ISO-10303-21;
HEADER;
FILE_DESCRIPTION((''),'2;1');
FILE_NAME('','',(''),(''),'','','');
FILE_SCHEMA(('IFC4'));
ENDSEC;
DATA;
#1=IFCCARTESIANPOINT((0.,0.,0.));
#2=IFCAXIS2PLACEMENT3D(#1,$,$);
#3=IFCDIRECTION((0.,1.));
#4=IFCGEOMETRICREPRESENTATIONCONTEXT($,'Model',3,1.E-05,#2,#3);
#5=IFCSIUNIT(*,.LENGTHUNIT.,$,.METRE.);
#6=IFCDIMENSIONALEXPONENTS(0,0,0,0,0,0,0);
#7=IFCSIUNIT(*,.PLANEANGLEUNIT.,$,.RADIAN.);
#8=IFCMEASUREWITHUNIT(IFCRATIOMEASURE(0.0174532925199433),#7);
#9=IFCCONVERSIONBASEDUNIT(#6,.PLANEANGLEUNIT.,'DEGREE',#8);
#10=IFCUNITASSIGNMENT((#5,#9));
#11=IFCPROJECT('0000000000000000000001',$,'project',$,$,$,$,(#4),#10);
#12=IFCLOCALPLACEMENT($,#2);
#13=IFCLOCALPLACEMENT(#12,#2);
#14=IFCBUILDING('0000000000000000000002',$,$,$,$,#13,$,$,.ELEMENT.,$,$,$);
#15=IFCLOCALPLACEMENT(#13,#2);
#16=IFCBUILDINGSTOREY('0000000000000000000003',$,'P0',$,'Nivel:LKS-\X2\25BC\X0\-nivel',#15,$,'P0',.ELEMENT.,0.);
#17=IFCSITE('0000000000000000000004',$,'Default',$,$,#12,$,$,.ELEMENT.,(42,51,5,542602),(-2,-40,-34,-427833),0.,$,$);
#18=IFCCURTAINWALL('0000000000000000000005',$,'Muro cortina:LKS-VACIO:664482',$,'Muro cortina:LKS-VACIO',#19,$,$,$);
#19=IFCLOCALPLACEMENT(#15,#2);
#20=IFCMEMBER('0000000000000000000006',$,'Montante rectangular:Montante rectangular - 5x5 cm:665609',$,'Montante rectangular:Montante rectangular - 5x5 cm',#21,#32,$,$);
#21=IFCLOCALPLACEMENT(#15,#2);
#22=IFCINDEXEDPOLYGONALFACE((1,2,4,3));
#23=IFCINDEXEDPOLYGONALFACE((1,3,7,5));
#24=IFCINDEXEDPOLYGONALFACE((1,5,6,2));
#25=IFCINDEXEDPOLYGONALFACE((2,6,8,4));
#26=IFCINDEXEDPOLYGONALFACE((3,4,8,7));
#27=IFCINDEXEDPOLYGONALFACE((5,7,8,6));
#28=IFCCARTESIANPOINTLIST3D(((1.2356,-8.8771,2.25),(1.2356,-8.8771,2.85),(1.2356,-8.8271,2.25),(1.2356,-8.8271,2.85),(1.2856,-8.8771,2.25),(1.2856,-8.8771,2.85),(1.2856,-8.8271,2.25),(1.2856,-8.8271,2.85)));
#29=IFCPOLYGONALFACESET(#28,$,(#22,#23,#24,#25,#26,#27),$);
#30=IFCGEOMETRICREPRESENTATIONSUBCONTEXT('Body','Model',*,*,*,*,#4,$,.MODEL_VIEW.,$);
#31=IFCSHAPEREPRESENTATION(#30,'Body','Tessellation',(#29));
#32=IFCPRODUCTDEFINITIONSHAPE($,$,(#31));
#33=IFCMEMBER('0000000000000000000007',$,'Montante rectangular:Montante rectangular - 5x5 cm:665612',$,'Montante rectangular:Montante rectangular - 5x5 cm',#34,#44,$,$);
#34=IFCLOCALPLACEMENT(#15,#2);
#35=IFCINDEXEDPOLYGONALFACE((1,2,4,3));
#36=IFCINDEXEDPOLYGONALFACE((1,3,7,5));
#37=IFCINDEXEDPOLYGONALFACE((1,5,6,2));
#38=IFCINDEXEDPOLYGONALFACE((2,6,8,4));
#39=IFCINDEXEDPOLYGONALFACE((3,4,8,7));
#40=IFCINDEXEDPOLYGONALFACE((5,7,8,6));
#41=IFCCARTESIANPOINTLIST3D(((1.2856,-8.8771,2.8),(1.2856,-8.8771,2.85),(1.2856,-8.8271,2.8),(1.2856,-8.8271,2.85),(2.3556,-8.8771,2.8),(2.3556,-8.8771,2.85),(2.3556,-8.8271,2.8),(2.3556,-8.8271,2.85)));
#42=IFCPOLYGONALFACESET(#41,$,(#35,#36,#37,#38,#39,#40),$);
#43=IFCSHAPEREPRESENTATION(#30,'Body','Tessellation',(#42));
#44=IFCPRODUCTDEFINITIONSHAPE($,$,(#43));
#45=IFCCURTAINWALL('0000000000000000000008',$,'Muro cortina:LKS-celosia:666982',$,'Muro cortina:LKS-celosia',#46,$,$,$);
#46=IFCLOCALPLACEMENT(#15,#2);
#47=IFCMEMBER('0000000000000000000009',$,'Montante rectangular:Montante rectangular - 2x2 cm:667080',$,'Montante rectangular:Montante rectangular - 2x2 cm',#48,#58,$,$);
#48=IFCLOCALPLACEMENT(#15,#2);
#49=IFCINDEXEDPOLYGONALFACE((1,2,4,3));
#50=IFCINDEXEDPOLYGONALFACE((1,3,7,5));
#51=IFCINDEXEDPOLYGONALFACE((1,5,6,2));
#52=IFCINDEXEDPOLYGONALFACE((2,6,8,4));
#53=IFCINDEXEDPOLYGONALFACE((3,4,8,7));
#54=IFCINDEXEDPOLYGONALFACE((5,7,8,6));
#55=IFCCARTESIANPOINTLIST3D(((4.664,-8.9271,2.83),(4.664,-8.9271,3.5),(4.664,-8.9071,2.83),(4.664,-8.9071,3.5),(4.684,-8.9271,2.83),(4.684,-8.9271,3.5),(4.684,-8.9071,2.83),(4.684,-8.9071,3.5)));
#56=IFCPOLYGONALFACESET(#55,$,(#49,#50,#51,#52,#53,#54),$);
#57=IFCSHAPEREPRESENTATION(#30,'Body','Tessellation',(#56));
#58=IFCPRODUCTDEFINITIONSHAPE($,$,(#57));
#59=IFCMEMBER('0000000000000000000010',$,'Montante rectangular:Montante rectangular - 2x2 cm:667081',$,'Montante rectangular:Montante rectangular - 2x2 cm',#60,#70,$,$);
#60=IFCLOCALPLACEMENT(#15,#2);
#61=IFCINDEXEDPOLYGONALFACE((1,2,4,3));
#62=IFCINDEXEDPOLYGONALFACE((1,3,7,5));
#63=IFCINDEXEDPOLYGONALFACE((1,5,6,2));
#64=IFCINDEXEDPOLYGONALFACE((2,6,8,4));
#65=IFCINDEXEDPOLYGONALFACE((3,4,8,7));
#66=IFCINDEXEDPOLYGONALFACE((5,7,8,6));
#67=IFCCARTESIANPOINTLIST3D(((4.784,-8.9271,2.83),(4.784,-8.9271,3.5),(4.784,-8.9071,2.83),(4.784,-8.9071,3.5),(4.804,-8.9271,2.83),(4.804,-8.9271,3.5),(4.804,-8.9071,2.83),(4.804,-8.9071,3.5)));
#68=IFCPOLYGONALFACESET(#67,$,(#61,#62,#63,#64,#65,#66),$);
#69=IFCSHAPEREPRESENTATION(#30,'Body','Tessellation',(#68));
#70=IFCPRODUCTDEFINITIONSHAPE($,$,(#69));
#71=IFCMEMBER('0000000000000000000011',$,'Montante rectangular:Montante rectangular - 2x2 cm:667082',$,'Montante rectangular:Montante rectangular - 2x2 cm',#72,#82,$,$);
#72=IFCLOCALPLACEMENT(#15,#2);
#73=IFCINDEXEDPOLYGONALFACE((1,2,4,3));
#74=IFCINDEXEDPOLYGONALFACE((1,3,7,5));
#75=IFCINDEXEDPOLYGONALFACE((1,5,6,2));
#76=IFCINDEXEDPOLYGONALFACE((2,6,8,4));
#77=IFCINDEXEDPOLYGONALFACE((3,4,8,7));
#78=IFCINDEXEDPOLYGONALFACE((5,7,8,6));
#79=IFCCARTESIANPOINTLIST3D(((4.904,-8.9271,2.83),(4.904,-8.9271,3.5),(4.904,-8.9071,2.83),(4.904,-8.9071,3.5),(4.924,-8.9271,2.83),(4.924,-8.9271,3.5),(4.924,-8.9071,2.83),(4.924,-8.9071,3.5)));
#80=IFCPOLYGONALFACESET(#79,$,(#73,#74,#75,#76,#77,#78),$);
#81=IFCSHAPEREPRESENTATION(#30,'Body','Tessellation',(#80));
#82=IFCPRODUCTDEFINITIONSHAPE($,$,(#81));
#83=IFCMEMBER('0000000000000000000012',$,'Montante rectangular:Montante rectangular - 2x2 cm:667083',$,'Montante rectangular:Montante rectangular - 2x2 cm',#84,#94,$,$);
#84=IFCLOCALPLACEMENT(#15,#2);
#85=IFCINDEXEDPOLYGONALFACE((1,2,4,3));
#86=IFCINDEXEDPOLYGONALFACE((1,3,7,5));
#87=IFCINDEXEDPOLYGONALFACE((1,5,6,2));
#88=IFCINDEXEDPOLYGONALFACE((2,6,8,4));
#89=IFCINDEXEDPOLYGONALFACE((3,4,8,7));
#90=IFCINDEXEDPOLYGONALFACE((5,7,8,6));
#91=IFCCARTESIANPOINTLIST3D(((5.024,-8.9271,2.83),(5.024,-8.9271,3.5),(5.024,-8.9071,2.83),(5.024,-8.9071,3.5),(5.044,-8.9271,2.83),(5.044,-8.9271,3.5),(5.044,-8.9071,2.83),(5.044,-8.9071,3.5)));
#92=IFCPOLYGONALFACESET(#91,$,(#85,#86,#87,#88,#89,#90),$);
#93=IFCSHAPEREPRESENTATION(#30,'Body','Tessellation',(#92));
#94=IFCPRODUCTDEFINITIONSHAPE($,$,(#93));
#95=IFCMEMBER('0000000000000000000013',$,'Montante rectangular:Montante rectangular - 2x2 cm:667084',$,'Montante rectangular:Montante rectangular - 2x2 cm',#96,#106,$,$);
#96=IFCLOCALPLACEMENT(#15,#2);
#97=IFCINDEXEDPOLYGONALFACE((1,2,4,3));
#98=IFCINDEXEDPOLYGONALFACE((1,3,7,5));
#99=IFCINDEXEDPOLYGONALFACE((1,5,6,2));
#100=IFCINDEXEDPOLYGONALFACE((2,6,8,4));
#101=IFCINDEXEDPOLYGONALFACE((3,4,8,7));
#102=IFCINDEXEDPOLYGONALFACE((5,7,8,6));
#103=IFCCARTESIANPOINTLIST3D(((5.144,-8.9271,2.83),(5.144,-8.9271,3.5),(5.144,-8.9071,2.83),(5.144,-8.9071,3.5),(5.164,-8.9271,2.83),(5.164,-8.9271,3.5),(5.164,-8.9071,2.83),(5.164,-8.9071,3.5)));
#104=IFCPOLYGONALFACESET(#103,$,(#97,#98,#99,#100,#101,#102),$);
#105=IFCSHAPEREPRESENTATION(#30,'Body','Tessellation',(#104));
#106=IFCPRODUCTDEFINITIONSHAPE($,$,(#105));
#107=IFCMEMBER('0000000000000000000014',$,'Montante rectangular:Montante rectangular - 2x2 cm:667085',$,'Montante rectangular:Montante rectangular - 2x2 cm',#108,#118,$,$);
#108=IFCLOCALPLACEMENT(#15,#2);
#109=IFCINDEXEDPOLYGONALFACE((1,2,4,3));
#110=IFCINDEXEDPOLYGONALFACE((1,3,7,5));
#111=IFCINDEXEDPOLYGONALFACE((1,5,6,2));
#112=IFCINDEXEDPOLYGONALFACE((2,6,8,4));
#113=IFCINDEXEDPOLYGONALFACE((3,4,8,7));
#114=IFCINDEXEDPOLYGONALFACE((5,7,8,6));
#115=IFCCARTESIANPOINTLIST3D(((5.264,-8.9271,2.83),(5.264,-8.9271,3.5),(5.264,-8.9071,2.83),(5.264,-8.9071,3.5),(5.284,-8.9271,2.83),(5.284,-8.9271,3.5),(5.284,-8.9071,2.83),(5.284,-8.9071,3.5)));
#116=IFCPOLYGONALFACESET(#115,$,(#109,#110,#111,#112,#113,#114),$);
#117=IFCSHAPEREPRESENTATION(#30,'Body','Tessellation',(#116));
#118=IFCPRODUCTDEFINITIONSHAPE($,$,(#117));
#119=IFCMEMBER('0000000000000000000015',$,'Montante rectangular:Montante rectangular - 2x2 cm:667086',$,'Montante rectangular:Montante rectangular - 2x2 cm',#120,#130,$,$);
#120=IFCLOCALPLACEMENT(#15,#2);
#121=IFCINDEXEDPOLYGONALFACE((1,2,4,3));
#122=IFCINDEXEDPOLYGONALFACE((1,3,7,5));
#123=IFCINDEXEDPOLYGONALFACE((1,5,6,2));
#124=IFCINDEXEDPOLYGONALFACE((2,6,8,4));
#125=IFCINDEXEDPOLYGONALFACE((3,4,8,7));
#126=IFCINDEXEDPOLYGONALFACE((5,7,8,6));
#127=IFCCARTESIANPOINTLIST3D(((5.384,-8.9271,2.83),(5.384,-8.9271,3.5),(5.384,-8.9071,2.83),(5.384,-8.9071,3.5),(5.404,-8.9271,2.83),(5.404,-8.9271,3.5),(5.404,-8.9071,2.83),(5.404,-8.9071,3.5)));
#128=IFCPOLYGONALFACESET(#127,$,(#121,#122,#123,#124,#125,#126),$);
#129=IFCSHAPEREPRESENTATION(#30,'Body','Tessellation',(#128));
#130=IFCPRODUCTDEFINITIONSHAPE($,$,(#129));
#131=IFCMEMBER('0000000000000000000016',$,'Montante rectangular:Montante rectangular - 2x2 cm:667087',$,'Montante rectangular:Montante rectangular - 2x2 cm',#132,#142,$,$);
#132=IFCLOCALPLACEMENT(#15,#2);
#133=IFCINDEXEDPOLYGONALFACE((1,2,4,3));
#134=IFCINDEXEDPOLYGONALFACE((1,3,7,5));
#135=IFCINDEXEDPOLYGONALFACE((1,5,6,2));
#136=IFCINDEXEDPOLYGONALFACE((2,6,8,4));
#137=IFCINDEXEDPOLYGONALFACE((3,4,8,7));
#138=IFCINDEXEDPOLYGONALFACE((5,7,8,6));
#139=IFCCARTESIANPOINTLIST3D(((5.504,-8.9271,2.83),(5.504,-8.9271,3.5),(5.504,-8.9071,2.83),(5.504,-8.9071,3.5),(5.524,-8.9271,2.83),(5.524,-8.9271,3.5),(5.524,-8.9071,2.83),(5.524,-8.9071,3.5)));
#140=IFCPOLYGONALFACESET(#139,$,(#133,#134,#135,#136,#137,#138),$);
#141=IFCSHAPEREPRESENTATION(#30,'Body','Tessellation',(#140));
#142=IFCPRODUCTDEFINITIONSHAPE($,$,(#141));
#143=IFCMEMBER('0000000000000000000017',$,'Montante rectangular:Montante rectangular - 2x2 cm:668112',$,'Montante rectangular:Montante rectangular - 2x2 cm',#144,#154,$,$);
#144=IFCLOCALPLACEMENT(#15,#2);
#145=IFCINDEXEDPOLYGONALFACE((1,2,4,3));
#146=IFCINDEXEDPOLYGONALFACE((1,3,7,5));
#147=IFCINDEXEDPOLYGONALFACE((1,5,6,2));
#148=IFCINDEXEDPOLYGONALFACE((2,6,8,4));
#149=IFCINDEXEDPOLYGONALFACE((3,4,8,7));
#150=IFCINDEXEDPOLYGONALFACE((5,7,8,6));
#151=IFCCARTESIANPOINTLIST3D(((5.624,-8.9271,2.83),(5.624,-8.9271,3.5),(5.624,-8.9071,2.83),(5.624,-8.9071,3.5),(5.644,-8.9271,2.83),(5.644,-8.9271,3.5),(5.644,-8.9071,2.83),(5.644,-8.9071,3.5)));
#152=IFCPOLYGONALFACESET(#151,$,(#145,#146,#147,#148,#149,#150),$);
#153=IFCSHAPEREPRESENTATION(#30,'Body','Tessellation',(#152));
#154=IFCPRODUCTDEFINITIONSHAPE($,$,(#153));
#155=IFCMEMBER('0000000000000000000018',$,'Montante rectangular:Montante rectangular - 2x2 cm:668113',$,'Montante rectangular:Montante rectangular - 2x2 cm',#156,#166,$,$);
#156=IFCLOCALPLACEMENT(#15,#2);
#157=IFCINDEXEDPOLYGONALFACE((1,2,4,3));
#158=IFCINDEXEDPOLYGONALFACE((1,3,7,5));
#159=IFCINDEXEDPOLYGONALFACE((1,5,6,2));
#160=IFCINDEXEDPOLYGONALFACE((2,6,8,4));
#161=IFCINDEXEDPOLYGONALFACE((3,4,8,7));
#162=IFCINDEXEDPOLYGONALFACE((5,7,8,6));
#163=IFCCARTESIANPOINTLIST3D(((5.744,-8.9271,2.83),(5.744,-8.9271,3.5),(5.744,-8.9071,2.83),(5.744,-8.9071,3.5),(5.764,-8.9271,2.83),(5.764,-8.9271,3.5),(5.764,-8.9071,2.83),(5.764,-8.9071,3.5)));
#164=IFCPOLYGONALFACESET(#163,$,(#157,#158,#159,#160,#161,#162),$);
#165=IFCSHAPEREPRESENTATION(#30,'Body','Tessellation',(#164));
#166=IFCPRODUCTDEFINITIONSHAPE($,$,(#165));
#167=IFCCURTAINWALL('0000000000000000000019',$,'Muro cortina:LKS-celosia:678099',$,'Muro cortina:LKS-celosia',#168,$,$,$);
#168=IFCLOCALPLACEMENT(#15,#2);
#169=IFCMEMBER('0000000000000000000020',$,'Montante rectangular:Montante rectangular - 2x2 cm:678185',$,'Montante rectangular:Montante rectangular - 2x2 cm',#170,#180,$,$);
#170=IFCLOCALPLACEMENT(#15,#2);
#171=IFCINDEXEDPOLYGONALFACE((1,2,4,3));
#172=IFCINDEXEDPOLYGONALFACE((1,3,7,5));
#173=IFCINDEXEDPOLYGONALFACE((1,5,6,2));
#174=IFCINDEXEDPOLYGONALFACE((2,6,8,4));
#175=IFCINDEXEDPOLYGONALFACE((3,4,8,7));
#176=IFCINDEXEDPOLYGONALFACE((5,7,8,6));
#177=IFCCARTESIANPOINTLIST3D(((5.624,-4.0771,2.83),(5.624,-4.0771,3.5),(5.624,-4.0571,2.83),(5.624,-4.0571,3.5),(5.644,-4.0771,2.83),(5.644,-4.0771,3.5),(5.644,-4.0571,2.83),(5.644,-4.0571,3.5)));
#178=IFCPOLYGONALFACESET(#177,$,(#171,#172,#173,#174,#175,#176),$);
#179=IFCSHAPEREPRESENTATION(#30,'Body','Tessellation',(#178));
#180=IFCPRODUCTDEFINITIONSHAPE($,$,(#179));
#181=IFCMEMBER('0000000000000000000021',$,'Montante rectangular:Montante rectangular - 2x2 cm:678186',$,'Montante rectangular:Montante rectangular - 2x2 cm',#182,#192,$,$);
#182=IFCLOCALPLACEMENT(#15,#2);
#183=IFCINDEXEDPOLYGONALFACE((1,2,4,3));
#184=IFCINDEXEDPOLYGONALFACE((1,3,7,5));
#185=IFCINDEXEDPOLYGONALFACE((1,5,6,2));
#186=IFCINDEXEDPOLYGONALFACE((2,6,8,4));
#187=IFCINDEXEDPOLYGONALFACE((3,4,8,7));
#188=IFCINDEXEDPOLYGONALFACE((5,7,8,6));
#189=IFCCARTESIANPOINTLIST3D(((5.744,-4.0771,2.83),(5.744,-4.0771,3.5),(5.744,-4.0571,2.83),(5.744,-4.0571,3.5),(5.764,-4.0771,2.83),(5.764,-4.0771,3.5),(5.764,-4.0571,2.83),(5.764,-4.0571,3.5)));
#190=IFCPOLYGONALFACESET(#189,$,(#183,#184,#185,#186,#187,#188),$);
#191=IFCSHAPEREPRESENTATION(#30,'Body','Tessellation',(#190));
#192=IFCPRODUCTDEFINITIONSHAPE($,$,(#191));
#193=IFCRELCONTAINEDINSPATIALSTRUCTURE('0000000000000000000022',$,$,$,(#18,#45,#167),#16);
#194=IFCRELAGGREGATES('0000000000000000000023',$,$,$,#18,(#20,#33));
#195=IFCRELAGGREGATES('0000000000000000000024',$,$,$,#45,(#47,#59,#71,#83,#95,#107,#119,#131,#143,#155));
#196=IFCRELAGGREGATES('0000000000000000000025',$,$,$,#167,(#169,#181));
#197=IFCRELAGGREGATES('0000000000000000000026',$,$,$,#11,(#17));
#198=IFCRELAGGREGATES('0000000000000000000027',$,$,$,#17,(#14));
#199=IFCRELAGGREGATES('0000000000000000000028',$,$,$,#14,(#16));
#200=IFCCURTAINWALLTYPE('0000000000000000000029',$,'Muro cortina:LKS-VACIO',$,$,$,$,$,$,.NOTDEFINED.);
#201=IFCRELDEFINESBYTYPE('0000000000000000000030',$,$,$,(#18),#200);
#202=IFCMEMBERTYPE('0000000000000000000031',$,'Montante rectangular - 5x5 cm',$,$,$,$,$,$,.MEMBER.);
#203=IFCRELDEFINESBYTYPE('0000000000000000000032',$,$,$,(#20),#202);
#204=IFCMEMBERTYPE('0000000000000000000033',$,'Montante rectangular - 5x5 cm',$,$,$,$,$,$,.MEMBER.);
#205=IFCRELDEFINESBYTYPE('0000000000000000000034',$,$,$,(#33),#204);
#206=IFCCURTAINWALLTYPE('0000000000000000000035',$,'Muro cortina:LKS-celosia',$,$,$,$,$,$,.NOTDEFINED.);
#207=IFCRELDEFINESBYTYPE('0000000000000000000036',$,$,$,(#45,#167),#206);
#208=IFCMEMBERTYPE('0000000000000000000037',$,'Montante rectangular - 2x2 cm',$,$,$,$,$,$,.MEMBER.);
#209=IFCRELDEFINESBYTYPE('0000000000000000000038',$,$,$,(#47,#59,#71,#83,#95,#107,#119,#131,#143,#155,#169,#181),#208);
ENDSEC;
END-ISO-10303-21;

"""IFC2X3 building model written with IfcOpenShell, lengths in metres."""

from ifc_helpers import new_model, entity, si_unit, converted_unit, direction, frame, origin, origin_2d_with_axis, place, context, subcontext, project, spatial, rectangle, extrude, source, transform, mapped, type_object, type_shapes, element, aggregate, save


model = new_model("IFC2X3")

# Units and contexts
model_context = context("Model", 3, precision=1e-05, world=origin(), true_north=direction((0.0, 1.0)))
body_context = subcontext(model_context, "Body", "Model", "MODEL_VIEW")
ifc_project = project(units=[si_unit("LENGTHUNIT", "METRE"), converted_unit("PLANEANGLEUNIT", "DEGREE", entity("IfcRatioMeasure", 0.0174532925199433), si_unit("PLANEANGLEUNIT", "RADIAN"), dimensions=[0, 0, 0, 0, 0, 0, 0])], contexts=[model_context])

# Site, building, storey
site_placement = place(None, origin())
site = spatial("IfcSite", under=ifc_project, at=site_placement, Name="Default", CompositionType="ELEMENT", RefLatitude=(42, 51, 5, 542602), RefLongitude=(-2, -40, -34, -427833), RefElevation=0.0)
building_placement = place(site_placement, origin())
building = spatial("IfcBuilding", under=site, at=building_placement, CompositionType="ELEMENT")
storey_placement = place(building_placement, origin())
storey = spatial("IfcBuildingStorey", under=building, at=storey_placement, Name="P0", ObjectType="Nivel:LKS-▼-nivel", LongName="P0", CompositionType="ELEMENT", Elevation=0.0)

# Curtain walls, members
curtain_wall_type_1 = type_object("IfcCurtainWallType", Name="Muro cortina:LKS-VACIO", PredefinedType="NOTDEFINED")
curtain_wall_1_placement = place(storey_placement, origin())
curtain_wall_1 = element("IfcCurtainWall", 1, at=curtain_wall_1_placement, inside=storey, type_object=curtain_wall_type_1, Name="Muro cortina:LKS-VACIO:664482", ObjectType="Muro cortina:LKS-VACIO")
member_type_1 = type_object("IfcMemberType", Name="Montante rectangular - 5x5 cm", PredefinedType="MEMBER")
shared_shape_1 = source(origin(), body_context, "Body", "SweptSolid", [
    extrude(rectangle(XDim=0.05, YDim=0.05, at=origin_2d_with_axis()), frame((-0.025, -0.1, -0.6), z_axis=(0.0, 0.0, 1.0), x_axis=(0.0, -1.0, 0.0)), (0.0, 0.0, 1.0), 0.6),
])
type_shapes(member_type_1, [shared_shape_1])
member_1_placement = place(storey_placement, frame((1.2356, -8.9521, 2.85), z_axis=(0.0, 0.0, 1.0), x_axis=(-1.0, 0.0, 0.0)))
member_1 = element("IfcMember", 2, at=member_1_placement, type_object=member_type_1, Name="Montante rectangular:Montante rectangular - 5x5 cm:665609", ObjectType="Montante rectangular:Montante rectangular - 5x5 cm", context=body_context, shape_type="MappedRepresentation", body=[
    mapped(shared_shape_1, transform((0.0, 0.0, 0.0), scale=1.0)),
])
member_type_2 = type_object("IfcMemberType", Name="Montante rectangular - 5x5 cm", PredefinedType="MEMBER")
shared_shape_2 = source(origin(), body_context, "Body", "SweptSolid", [
    extrude(rectangle(XDim=0.05, YDim=0.05, at=origin_2d_with_axis()), frame((-0.025, -0.1, -1.07), z_axis=(0.0, 0.0, 1.0), x_axis=(0.0, -1.0, 0.0)), (0.0, 0.0, 1.0), 1.07),
])
type_shapes(member_type_2, [shared_shape_2])
member_2_placement = place(storey_placement, frame((2.3556, -8.9521, 2.85), z_axis=(1.0, 0.0, 0.0), x_axis=(0.0, 0.0, 1.0)))
member_2 = element("IfcMember", 3, at=member_2_placement, type_object=member_type_2, Name="Montante rectangular:Montante rectangular - 5x5 cm:665612", ObjectType="Montante rectangular:Montante rectangular - 5x5 cm", context=body_context, shape_type="MappedRepresentation", body=[
    mapped(shared_shape_2, transform((0.0, 0.0, 0.0), scale=1.0)),
])
aggregate(curtain_wall_1, [member_1, member_2])
curtain_wall_type_2 = type_object("IfcCurtainWallType", Name="Muro cortina:LKS-celosia", PredefinedType="NOTDEFINED")
curtain_wall_2_placement = place(storey_placement, origin())
curtain_wall_2 = element("IfcCurtainWall", 4, at=curtain_wall_2_placement, inside=storey, type_object=curtain_wall_type_2, Name="Muro cortina:LKS-celosia:666982", ObjectType="Muro cortina:LKS-celosia")
member_type_3 = type_object("IfcMemberType", Name="Montante rectangular - 2x2 cm", PredefinedType="MEMBER")
shared_shape_3 = source(origin(), body_context, "Body", "SweptSolid", [
    extrude(rectangle(XDim=0.02, YDim=0.02, at=origin_2d_with_axis()), frame((0.0, -0.1, -0.67), z_axis=(0.0, 0.0, 1.0), x_axis=(0.0, -1.0, 0.0)), (0.0, 0.0, 1.0), 0.67),
])
type_shapes(member_type_3, [shared_shape_3])
member_3_placement = place(storey_placement, frame((4.674, -9.0171, 2.83), z_axis=(0.0, 0.0, -1.0), x_axis=(1.0, 0.0, 0.0)))
member_3 = element("IfcMember", 5, at=member_3_placement, type_object=member_type_3, Name="Montante rectangular:Montante rectangular - 2x2 cm:667080", ObjectType="Montante rectangular:Montante rectangular - 2x2 cm", context=body_context, shape_type="MappedRepresentation", body=[
    mapped(shared_shape_3, transform((0.0, 0.0, 0.0), scale=1.0)),
])
member_4_placement = place(storey_placement, frame((4.794, -9.0171, 2.83), z_axis=(0.0, 0.0, -1.0), x_axis=(1.0, 0.0, 0.0)))
member_4 = element("IfcMember", 6, at=member_4_placement, type_object=member_type_3, Name="Montante rectangular:Montante rectangular - 2x2 cm:667081", ObjectType="Montante rectangular:Montante rectangular - 2x2 cm", context=body_context, shape_type="MappedRepresentation", body=[
    mapped(shared_shape_3, transform((0.0, 0.0, 0.0), scale=1.0)),
])
member_5_placement = place(storey_placement, frame((4.914, -9.0171, 2.83), z_axis=(0.0, 0.0, -1.0), x_axis=(1.0, 0.0, 0.0)))
member_5 = element("IfcMember", 7, at=member_5_placement, type_object=member_type_3, Name="Montante rectangular:Montante rectangular - 2x2 cm:667082", ObjectType="Montante rectangular:Montante rectangular - 2x2 cm", context=body_context, shape_type="MappedRepresentation", body=[
    mapped(shared_shape_3, transform((0.0, 0.0, 0.0), scale=1.0)),
])
member_6_placement = place(storey_placement, frame((5.034, -9.0171, 2.83), z_axis=(0.0, 0.0, -1.0), x_axis=(1.0, 0.0, 0.0)))
member_6 = element("IfcMember", 8, at=member_6_placement, type_object=member_type_3, Name="Montante rectangular:Montante rectangular - 2x2 cm:667083", ObjectType="Montante rectangular:Montante rectangular - 2x2 cm", context=body_context, shape_type="MappedRepresentation", body=[
    mapped(shared_shape_3, transform((0.0, 0.0, 0.0), scale=1.0)),
])
member_7_placement = place(storey_placement, frame((5.154, -9.0171, 2.83), z_axis=(0.0, 0.0, -1.0), x_axis=(1.0, 0.0, 0.0)))
member_7 = element("IfcMember", 9, at=member_7_placement, type_object=member_type_3, Name="Montante rectangular:Montante rectangular - 2x2 cm:667084", ObjectType="Montante rectangular:Montante rectangular - 2x2 cm", context=body_context, shape_type="MappedRepresentation", body=[
    mapped(shared_shape_3, transform((0.0, 0.0, 0.0), scale=1.0)),
])
member_8_placement = place(storey_placement, frame((5.274, -9.0171, 2.83), z_axis=(0.0, 0.0, -1.0), x_axis=(1.0, 0.0, 0.0)))
member_8 = element("IfcMember", 10, at=member_8_placement, type_object=member_type_3, Name="Montante rectangular:Montante rectangular - 2x2 cm:667085", ObjectType="Montante rectangular:Montante rectangular - 2x2 cm", context=body_context, shape_type="MappedRepresentation", body=[
    mapped(shared_shape_3, transform((0.0, 0.0, 0.0), scale=1.0)),
])
member_9_placement = place(storey_placement, frame((5.394, -9.0171, 2.83), z_axis=(0.0, 0.0, -1.0), x_axis=(1.0, 0.0, 0.0)))
member_9 = element("IfcMember", 11, at=member_9_placement, type_object=member_type_3, Name="Montante rectangular:Montante rectangular - 2x2 cm:667086", ObjectType="Montante rectangular:Montante rectangular - 2x2 cm", context=body_context, shape_type="MappedRepresentation", body=[
    mapped(shared_shape_3, transform((0.0, 0.0, 0.0), scale=1.0)),
])
member_10_placement = place(storey_placement, frame((5.514, -9.0171, 2.83), z_axis=(0.0, 0.0, -1.0), x_axis=(1.0, 0.0, 0.0)))
member_10 = element("IfcMember", 12, at=member_10_placement, type_object=member_type_3, Name="Montante rectangular:Montante rectangular - 2x2 cm:667087", ObjectType="Montante rectangular:Montante rectangular - 2x2 cm", context=body_context, shape_type="MappedRepresentation", body=[
    mapped(shared_shape_3, transform((0.0, 0.0, 0.0), scale=1.0)),
])
member_11_placement = place(storey_placement, frame((5.634, -9.0171, 2.83), z_axis=(0.0, 0.0, -1.0), x_axis=(1.0, 0.0, 0.0)))
member_11 = element("IfcMember", 13, at=member_11_placement, type_object=member_type_3, Name="Montante rectangular:Montante rectangular - 2x2 cm:668112", ObjectType="Montante rectangular:Montante rectangular - 2x2 cm", context=body_context, shape_type="MappedRepresentation", body=[
    mapped(shared_shape_3, transform((0.0, 0.0, 0.0), scale=1.0)),
])
member_12_placement = place(storey_placement, frame((5.754, -9.0171, 2.83), z_axis=(0.0, 0.0, -1.0), x_axis=(1.0, 0.0, 0.0)))
member_12 = element("IfcMember", 14, at=member_12_placement, type_object=member_type_3, Name="Montante rectangular:Montante rectangular - 2x2 cm:668113", ObjectType="Montante rectangular:Montante rectangular - 2x2 cm", context=body_context, shape_type="MappedRepresentation", body=[
    mapped(shared_shape_3, transform((0.0, 0.0, 0.0), scale=1.0)),
])
curtain_wall_3_placement = place(storey_placement, origin())
curtain_wall_3 = element("IfcCurtainWall", 15, at=curtain_wall_3_placement, inside=storey, type_object=curtain_wall_type_2, Name="Muro cortina:LKS-celosia:678099", ObjectType="Muro cortina:LKS-celosia")
member_13_placement = place(storey_placement, frame((5.634, -4.1671, 2.83), z_axis=(0.0, 0.0, -1.0), x_axis=(1.0, 0.0, 0.0)))
member_13 = element("IfcMember", 16, at=member_13_placement, type_object=member_type_3, Name="Montante rectangular:Montante rectangular - 2x2 cm:678185", ObjectType="Montante rectangular:Montante rectangular - 2x2 cm", context=body_context, shape_type="MappedRepresentation", body=[
    mapped(shared_shape_3, transform((0.0, 0.0, 0.0), scale=1.0)),
])
member_14_placement = place(storey_placement, frame((5.754, -4.1671, 2.83), z_axis=(0.0, 0.0, -1.0), x_axis=(1.0, 0.0, 0.0)))
member_14 = element("IfcMember", 17, at=member_14_placement, type_object=member_type_3, Name="Montante rectangular:Montante rectangular - 2x2 cm:678186", ObjectType="Montante rectangular:Montante rectangular - 2x2 cm", context=body_context, shape_type="MappedRepresentation", body=[
    mapped(shared_shape_3, transform((0.0, 0.0, 0.0), scale=1.0)),
])

aggregate(curtain_wall_2, [member_3, member_4, member_5, member_6, member_7, member_8, member_9, member_10, member_11, member_12])
aggregate(curtain_wall_3, [member_13, member_14])

save(model, "model.ifc")
